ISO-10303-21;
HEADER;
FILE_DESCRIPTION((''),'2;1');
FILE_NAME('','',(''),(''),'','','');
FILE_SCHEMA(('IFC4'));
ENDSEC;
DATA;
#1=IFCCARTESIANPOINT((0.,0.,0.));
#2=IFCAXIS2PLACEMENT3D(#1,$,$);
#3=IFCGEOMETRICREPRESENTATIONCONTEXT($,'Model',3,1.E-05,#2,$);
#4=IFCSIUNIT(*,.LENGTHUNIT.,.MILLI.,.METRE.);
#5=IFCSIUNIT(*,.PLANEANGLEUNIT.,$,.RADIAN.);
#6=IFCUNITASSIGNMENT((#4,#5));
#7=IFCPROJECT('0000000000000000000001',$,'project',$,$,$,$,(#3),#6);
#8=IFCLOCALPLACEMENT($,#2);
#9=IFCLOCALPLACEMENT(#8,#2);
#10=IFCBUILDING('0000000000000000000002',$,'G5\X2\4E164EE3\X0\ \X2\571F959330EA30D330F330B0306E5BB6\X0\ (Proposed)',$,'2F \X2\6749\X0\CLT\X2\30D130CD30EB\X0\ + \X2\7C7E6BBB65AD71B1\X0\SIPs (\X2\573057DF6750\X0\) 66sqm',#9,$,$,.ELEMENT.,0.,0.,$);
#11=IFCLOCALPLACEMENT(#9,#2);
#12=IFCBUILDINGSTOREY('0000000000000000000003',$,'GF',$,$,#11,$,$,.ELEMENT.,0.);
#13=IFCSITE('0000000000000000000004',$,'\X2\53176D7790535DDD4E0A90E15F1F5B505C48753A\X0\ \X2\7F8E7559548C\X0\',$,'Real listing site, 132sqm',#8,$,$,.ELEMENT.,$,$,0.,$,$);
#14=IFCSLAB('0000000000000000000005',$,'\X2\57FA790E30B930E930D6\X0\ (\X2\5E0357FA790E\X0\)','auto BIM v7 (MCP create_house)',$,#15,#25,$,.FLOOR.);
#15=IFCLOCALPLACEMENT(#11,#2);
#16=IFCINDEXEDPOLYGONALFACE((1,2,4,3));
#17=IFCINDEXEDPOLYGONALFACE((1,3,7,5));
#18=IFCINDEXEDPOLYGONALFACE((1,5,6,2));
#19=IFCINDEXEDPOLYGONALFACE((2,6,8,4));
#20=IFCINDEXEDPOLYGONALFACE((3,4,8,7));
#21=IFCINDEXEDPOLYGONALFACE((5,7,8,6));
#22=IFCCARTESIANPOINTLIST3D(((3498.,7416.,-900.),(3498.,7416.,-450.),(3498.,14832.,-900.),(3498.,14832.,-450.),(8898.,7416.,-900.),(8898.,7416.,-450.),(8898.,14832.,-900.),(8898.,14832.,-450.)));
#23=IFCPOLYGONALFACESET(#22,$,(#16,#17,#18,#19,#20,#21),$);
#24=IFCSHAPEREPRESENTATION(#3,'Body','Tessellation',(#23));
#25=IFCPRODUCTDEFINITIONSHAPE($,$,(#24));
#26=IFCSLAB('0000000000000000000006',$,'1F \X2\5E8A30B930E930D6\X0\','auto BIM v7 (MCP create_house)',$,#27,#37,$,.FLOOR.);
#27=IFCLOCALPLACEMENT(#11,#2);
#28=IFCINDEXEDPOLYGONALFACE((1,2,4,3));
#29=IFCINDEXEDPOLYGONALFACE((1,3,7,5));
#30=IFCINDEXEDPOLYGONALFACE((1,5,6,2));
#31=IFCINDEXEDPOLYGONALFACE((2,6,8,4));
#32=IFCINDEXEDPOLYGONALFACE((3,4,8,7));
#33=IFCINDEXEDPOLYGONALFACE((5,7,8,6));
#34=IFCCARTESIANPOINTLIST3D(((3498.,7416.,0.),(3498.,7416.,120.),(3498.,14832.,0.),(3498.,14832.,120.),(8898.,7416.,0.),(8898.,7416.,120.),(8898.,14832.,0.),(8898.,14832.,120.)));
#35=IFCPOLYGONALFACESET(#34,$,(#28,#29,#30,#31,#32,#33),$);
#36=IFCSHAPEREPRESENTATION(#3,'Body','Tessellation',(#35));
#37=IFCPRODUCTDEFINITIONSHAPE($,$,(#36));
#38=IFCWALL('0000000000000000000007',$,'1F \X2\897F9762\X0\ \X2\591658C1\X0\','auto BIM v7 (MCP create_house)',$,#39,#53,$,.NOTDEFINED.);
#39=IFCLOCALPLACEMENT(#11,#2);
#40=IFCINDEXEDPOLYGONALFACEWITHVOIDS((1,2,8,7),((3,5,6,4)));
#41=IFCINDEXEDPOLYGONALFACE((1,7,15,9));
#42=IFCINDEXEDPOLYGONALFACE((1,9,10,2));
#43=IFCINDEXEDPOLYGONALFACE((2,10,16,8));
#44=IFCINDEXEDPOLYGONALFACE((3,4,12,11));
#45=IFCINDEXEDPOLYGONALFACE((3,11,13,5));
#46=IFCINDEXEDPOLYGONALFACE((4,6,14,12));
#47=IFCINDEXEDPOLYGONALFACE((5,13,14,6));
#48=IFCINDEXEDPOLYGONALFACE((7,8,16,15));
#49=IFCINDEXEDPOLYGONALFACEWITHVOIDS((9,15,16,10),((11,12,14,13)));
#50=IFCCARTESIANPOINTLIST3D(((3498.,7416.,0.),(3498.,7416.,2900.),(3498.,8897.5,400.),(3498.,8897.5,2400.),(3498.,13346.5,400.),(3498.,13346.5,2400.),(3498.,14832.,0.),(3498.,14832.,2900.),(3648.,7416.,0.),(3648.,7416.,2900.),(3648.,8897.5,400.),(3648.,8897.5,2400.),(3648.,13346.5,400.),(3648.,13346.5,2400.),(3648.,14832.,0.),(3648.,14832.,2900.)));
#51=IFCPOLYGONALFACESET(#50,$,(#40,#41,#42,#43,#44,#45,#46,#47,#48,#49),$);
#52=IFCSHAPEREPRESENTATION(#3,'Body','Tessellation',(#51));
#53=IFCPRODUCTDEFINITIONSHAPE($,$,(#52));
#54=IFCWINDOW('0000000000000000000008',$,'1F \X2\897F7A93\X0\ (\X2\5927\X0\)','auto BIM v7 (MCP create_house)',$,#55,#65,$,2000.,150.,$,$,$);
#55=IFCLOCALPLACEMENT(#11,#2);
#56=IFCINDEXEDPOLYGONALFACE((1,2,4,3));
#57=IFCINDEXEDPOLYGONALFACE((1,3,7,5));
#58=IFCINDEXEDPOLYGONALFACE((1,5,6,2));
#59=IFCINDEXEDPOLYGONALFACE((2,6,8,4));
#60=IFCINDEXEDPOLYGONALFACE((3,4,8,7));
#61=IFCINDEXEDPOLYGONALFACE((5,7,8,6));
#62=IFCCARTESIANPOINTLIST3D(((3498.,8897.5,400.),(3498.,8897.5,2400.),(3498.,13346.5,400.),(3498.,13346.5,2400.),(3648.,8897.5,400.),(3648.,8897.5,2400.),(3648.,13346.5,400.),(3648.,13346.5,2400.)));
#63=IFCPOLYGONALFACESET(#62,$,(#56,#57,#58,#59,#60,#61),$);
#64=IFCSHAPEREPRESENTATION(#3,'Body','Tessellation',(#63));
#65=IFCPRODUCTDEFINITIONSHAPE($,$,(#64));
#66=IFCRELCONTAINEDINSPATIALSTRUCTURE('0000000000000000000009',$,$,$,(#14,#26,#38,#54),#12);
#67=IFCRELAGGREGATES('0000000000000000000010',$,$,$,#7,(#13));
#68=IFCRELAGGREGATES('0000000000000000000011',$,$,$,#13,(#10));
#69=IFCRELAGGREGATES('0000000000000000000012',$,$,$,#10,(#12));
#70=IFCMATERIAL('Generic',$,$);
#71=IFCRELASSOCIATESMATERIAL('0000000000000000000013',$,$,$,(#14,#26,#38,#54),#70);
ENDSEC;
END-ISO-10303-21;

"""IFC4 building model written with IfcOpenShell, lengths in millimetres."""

from ifc_helpers import new_model, si_unit, frame, frame_2d, origin, place, context, project, spatial, rectangle, extrude, material, element, fill, save


model = new_model("IFC4")

# Units and contexts
model_context = context("Model", 3, precision=1e-05, world=origin())
ifc_project = project(units=[si_unit("LENGTHUNIT", "METRE", prefix="MILLI"), si_unit("PLANEANGLEUNIT", "RADIAN")], contexts=[model_context])

# Site, building, storey
site_placement = place(None, origin())
site = spatial("IfcSite", under=ifc_project, at=site_placement, Name="北海道川上郡弟子屈町 美留和", ObjectType="Real listing site, 132sqm", CompositionType="ELEMENT", RefElevation=0.0)
building_placement = place(site_placement, origin())
building = spatial("IfcBuilding", under=site, at=building_placement, Name="G5世代 土間リビングの家 (Proposed)", ObjectType="2F 杉CLTパネル + 籾殻断熱SIPs (地域材) 66sqm", CompositionType="ELEMENT", ElevationOfRefHeight=0.0, ElevationOfTerrain=0.0)
storey_placement = place(building_placement, origin())
storey = spatial("IfcBuildingStorey", under=building, at=storey_placement, Name="GF", CompositionType="ELEMENT", Elevation=0.0)

# Slabs
ifc_material = material(Name="Generic")
slab_1_placement = place(storey_placement, frame((1749.0, 3708.0, -450.0)))
element("IfcSlab", 1, at=slab_1_placement, inside=storey, material=ifc_material, Name="基礎スラブ (布基礎)", Description="auto BIM v7 (MCP create_house)", PredefinedType="FLOOR", context=model_context, shape_type="SweptSolid", body=[
    extrude(rectangle(XDim=5400.0, YDim=7416.0, at=frame_2d((2700.0, 3708.0))), frame((1749.0, 3708.0, -450.0)), (0.0, 0.0, 1.0), 450.0),
])
slab_2_placement = place(storey_placement, frame((1749.0, 3708.0, 0.0)))
element("IfcSlab", 2, at=slab_2_placement, inside=storey, material=ifc_material, Name="1F 床スラブ", Description="auto BIM v7 (MCP create_house)", PredefinedType="FLOOR", context=model_context, shape_type="SweptSolid", body=[
    extrude(rectangle(XDim=5400.0, YDim=7416.0, at=frame_2d((2700.0, 3708.0))), frame((1749.0, 3708.0, 0.0)), (0.0, 0.0, 1.0), 120.0),
])

# Wall, opening, window
wall_1_placement = place(storey_placement, frame((1749.0, 3708.0, 0.0)))
wall_1 = element("IfcWall", 3, at=wall_1_placement, inside=storey, material=ifc_material, Name="1F 西面 外壁", Description="auto BIM v7 (MCP create_house)", PredefinedType="NOTDEFINED", context=model_context, shape_type="SweptSolid", body=[
    extrude(rectangle(XDim=150.0, YDim=7416.0, at=frame_2d((75.0, 3708.0))), frame((1749.0, 3708.0, 0.0)), (0.0, 0.0, 1.0), 2900.0),
])
opening_1_placement = place(storey_placement, frame((1749.0, 4449.0, 200.0)))
opening_1 = element("IfcOpeningElement", 4, at=opening_1_placement, cuts=wall_1, PredefinedType="NOTDEFINED", context=model_context, shape_type="SweptSolid", body=[
    extrude(rectangle(XDim=150.0, YDim=4449.0, at=frame_2d((75.0, 2224.0))), frame((1749.0, 4449.0, 200.0)), (0.0, 0.0, 1.0), 2000.0),
])
window_1_placement = place(storey_placement, frame((1749.0, 4449.0, 200.0)))
window_1 = element("IfcWindow", 5, at=window_1_placement, inside=storey, material=ifc_material, Name="1F 西窓 (大)", Description="auto BIM v7 (MCP create_house)", OverallHeight=2000.0, OverallWidth=150.0, context=model_context, shape_type="SweptSolid", body=[
    extrude(rectangle(XDim=150.0, YDim=4449.0, at=frame_2d((75.0, 2224.0))), frame((1749.0, 4449.0, 200.0)), (0.0, 0.0, 1.0), 2000.0),
])
fill(opening_1, window_1)

save(model, "model.ifc")
